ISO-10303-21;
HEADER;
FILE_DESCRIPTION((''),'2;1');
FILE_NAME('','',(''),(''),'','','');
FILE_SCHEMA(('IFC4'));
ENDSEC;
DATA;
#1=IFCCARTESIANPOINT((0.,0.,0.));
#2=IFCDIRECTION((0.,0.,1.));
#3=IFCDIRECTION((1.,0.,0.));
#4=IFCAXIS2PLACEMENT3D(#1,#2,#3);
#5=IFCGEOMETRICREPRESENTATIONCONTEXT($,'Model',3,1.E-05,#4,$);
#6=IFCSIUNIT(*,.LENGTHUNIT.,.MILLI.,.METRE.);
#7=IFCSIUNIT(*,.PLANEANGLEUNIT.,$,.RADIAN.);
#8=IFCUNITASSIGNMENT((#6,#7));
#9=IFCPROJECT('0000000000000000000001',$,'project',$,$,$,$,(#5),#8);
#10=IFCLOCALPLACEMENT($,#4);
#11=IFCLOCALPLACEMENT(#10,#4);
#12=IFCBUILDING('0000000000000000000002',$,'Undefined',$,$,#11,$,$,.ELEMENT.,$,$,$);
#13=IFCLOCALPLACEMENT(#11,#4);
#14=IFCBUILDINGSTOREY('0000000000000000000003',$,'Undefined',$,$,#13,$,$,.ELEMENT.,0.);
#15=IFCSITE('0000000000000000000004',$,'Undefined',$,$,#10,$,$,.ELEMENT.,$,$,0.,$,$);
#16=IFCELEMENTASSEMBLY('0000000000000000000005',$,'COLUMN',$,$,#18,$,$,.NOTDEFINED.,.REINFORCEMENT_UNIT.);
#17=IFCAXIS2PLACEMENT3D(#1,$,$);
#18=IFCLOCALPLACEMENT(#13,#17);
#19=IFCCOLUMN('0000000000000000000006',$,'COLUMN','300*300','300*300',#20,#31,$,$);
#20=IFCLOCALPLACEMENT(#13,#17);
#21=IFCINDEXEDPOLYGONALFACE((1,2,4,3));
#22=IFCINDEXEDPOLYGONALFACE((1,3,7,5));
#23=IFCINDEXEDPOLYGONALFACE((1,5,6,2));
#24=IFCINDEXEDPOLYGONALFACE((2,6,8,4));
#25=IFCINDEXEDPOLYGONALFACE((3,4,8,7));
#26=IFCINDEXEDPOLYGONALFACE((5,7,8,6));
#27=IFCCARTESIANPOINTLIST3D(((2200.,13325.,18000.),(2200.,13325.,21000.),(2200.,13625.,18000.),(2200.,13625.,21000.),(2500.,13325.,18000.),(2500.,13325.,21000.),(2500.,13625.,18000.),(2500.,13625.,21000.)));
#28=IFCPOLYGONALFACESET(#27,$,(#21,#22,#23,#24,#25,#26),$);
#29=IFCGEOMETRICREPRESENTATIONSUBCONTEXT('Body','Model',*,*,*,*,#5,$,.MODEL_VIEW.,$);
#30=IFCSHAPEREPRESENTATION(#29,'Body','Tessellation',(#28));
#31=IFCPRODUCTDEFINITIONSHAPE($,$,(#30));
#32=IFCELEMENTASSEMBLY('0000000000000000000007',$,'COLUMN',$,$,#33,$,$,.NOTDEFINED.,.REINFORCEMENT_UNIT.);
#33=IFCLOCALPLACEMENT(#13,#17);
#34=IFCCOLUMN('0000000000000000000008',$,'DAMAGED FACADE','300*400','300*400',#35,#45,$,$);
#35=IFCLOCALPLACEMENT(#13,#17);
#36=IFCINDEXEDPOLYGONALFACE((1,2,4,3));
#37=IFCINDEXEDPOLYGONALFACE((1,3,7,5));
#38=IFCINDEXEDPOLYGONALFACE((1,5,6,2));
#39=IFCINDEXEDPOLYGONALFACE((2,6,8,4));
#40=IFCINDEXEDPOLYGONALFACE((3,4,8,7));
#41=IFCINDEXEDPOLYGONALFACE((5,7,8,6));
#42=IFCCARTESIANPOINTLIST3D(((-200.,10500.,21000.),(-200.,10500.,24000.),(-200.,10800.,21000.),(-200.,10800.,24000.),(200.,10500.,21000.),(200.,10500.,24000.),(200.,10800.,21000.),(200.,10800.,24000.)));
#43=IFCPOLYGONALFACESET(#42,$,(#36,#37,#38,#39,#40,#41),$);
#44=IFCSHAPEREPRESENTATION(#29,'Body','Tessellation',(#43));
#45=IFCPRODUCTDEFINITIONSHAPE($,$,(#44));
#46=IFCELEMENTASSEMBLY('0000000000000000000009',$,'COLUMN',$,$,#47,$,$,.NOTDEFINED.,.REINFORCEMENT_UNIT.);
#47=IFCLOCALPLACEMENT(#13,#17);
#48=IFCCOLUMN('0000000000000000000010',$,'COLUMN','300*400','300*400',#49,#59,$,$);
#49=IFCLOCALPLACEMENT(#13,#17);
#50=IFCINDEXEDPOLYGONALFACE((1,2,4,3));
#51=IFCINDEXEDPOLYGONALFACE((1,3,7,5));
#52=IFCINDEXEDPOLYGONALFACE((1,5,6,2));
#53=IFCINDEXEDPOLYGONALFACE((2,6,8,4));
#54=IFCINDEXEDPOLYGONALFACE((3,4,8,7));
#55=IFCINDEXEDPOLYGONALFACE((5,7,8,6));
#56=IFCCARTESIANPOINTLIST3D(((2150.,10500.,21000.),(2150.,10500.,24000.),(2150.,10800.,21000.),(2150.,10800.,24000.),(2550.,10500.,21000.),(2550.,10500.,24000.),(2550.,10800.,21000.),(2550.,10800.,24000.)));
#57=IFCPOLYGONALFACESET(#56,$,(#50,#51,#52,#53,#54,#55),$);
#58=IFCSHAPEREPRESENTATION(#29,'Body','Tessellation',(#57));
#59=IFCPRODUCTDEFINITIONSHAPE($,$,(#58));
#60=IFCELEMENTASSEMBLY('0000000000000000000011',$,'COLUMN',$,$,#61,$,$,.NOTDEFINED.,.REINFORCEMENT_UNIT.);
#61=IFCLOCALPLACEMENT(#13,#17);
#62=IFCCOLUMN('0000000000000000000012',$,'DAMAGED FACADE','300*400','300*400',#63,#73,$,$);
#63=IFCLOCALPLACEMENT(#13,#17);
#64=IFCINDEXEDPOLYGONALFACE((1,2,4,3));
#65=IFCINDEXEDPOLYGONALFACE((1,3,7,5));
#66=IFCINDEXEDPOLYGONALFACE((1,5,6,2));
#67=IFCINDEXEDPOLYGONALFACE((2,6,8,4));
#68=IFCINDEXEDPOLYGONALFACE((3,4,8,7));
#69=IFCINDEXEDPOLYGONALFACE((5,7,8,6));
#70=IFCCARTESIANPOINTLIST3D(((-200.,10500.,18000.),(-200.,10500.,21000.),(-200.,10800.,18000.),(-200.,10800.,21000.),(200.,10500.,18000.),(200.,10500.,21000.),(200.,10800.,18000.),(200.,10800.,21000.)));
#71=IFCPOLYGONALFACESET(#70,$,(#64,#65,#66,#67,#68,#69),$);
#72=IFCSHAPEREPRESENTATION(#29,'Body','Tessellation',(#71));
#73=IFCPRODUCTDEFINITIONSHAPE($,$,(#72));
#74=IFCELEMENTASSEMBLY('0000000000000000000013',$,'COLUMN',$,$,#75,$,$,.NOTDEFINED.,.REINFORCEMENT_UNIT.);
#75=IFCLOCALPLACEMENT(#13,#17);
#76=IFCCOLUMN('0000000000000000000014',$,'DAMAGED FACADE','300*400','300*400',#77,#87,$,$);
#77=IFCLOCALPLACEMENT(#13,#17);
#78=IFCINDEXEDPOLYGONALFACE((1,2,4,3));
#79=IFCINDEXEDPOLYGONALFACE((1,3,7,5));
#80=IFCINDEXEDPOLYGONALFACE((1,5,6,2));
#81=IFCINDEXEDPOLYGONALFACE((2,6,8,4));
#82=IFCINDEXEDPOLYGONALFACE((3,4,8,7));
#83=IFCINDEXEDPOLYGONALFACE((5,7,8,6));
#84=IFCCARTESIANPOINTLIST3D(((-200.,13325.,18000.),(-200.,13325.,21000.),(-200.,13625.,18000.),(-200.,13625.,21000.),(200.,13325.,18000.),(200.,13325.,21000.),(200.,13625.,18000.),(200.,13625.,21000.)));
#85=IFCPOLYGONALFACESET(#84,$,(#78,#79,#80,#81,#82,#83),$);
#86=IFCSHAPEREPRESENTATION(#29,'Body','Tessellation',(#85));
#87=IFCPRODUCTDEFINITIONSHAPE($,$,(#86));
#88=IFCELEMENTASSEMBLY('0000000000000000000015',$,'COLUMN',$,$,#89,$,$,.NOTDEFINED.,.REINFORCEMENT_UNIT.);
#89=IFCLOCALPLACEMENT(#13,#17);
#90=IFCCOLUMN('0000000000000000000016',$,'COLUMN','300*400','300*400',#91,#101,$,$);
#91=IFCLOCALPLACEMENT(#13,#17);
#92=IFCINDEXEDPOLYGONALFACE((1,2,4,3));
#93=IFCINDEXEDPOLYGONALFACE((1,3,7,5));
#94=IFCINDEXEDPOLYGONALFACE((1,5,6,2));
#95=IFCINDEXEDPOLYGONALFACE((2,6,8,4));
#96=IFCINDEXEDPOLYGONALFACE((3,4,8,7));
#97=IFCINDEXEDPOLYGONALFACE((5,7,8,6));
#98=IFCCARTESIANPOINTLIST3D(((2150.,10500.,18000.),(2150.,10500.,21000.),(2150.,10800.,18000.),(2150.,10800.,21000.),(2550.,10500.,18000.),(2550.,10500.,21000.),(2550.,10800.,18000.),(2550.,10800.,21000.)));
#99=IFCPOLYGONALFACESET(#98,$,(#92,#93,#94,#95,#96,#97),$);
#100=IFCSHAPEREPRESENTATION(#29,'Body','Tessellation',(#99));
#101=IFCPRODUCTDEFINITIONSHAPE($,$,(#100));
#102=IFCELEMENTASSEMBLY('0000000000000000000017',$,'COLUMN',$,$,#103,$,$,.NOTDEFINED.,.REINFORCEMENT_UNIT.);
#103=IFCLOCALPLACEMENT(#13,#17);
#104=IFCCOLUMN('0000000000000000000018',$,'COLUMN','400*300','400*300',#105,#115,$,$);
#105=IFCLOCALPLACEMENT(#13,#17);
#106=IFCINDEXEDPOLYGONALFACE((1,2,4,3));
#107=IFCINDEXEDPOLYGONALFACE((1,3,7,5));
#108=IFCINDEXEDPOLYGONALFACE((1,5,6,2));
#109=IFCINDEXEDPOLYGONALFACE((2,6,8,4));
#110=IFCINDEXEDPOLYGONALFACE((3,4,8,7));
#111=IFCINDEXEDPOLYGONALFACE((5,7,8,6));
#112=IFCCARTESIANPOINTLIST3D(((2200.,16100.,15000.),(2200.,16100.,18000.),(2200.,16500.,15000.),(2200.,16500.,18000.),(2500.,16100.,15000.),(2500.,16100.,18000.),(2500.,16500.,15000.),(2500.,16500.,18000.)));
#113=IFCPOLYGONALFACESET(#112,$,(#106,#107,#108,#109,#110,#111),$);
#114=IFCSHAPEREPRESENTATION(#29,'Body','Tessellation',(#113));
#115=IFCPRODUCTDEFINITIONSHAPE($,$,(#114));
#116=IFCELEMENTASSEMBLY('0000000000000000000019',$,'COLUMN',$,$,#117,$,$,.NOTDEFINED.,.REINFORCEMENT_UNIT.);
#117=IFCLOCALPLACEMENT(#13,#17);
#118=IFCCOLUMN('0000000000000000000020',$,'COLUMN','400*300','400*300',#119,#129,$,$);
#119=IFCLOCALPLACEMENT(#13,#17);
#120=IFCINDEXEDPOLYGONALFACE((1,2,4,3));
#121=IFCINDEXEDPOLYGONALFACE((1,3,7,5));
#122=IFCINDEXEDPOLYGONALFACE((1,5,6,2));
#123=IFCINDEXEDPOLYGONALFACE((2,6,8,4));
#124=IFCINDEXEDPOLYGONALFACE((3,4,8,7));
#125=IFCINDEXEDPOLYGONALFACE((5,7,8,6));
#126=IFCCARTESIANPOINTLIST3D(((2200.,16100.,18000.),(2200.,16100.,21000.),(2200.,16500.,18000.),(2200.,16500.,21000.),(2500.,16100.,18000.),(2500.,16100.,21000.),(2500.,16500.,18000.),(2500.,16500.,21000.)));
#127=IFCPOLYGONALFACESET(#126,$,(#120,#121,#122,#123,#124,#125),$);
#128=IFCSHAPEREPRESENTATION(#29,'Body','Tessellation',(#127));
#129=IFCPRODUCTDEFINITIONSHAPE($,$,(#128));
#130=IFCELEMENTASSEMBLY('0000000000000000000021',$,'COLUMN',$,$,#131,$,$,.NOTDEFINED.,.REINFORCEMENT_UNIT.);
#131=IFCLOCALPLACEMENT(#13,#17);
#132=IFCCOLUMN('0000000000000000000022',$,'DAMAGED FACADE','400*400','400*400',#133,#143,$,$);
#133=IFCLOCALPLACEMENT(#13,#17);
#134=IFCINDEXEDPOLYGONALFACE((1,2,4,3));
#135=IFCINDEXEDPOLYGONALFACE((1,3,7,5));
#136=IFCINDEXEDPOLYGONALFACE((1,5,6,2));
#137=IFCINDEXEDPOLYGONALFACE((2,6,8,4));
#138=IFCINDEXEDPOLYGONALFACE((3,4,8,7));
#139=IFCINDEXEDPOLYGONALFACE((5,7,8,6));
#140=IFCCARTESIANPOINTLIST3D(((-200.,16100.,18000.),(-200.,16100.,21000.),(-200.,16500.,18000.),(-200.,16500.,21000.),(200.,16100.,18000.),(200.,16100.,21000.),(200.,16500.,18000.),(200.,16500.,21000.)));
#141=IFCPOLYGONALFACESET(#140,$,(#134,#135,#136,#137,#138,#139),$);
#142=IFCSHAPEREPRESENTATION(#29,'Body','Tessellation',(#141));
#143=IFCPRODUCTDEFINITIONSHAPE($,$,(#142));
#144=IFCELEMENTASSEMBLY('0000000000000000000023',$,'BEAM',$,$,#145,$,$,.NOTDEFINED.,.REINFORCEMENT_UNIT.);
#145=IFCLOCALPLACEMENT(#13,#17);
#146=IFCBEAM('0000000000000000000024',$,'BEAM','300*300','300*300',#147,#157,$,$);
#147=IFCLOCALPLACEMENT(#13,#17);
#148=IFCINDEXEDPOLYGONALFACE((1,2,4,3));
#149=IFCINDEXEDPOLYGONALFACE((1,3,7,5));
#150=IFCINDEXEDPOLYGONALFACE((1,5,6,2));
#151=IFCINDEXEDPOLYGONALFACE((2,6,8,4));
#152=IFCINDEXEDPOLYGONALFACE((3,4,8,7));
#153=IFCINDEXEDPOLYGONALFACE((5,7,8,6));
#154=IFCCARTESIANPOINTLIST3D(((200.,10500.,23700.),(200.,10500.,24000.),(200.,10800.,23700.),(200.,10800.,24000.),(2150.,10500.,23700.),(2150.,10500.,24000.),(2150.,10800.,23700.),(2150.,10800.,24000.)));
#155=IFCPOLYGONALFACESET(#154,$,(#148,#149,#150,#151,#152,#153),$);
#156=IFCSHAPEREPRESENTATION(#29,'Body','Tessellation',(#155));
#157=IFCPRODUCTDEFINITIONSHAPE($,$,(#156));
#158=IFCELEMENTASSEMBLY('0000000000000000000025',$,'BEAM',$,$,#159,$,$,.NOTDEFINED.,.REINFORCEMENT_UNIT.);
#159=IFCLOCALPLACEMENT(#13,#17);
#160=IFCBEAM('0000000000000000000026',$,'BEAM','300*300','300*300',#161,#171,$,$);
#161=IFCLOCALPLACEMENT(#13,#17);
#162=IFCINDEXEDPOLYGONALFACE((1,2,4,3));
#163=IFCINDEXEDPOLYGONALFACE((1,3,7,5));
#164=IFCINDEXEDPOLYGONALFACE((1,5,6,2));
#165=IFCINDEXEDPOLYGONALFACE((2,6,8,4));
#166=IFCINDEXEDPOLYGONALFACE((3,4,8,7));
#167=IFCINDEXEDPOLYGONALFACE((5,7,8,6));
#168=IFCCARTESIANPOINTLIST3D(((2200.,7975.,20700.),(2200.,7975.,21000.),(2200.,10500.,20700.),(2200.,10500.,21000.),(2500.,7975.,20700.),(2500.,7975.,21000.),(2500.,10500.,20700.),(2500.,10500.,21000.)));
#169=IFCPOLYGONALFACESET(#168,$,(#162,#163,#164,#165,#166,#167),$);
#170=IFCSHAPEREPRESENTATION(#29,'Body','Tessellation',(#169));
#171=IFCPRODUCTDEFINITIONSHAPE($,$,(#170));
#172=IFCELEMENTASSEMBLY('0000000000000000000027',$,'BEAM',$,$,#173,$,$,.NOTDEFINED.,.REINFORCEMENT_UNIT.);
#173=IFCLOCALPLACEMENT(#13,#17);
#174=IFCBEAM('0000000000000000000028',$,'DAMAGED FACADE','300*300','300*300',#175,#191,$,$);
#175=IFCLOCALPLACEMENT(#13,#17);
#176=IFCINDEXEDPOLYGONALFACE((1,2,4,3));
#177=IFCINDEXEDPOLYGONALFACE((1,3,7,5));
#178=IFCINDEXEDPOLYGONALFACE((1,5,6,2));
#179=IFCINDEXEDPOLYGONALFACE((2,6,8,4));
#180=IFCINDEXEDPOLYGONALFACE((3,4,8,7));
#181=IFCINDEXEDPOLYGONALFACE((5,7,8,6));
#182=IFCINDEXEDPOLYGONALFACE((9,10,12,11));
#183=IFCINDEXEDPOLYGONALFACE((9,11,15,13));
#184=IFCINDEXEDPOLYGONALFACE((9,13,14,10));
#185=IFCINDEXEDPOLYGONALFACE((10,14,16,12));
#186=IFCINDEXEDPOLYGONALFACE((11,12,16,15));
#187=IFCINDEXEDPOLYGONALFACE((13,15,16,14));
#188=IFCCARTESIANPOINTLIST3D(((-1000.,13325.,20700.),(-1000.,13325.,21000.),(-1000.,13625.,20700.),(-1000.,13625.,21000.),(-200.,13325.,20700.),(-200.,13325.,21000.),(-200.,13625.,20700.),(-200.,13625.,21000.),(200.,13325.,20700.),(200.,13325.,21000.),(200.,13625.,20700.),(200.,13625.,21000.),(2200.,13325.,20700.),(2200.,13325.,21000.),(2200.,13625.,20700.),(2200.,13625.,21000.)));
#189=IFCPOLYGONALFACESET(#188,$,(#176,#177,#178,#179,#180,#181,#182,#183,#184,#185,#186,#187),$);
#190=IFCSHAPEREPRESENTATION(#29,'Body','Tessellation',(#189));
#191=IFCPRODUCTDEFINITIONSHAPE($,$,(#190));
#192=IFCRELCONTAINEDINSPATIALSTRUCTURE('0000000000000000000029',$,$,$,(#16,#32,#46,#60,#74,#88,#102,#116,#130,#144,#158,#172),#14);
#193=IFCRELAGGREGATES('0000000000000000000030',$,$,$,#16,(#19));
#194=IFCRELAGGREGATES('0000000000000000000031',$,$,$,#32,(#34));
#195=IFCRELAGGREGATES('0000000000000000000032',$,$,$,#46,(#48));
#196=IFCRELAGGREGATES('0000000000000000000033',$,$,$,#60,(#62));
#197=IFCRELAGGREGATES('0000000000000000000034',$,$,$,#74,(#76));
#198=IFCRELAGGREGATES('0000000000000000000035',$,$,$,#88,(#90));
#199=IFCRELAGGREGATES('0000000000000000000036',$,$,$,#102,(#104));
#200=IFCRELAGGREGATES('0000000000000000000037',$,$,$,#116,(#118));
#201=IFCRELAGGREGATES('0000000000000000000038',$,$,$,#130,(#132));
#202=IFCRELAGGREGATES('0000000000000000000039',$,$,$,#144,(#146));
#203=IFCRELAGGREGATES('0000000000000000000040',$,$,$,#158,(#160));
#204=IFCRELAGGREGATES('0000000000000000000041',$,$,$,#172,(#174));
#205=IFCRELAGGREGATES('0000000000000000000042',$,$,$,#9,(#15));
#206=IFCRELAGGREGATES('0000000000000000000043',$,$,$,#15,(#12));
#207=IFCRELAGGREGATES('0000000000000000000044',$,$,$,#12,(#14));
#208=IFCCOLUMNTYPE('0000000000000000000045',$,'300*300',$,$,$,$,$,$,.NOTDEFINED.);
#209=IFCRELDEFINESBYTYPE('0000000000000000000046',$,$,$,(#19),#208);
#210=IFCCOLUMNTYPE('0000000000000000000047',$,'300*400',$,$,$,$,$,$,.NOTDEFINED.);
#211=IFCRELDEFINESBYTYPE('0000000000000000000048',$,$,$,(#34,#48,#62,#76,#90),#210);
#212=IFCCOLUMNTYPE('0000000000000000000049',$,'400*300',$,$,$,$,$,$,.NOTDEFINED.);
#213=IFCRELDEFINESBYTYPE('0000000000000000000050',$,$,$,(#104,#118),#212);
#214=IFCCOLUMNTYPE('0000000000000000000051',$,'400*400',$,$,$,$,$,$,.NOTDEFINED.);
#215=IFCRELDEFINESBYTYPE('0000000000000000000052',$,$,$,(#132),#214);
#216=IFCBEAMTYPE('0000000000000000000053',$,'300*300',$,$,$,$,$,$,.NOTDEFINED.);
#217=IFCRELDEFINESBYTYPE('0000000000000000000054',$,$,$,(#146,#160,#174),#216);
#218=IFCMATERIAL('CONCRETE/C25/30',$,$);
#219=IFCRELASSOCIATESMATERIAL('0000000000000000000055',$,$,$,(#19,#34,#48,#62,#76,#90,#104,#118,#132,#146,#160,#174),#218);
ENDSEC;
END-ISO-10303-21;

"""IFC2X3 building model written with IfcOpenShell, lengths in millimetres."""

from ifc_helpers import new_model, si_unit, frame, origin_with_axes, origin_2d_with_axis, place, context, subcontext, project, spatial, rectangle, extrude, boolean, material, type_object, element, aggregate, save


model = new_model("IFC2X3")

# Units and contexts
model_context = context("Model", 3, precision=1e-05, world=origin_with_axes())
body_context = subcontext(model_context, "Body", "Model", "MODEL_VIEW")
ifc_project = project(units=[si_unit("LENGTHUNIT", "METRE", prefix="MILLI"), si_unit("PLANEANGLEUNIT", "RADIAN")], contexts=[model_context])

# Site, building, storey
site_placement = place(None, origin_with_axes())
site = spatial("IfcSite", under=ifc_project, at=site_placement, Name="Undefined", CompositionType="ELEMENT", RefElevation=0.0)
building_placement = place(site_placement, origin_with_axes())
building = spatial("IfcBuilding", under=site, at=building_placement, Name="Undefined", CompositionType="ELEMENT")
storey_placement = place(building_placement, origin_with_axes())
storey = spatial("IfcBuildingStorey", under=building, at=storey_placement, Name="Undefined", CompositionType="ELEMENT", Elevation=0.0)

# Element assemblies, columns
assembly_1_placement = place(storey_placement, origin_with_axes())
assembly_1 = element("IfcElementAssembly", 1, at=assembly_1_placement, inside=storey, Name="COLUMN", AssemblyPlace="NOTDEFINED", PredefinedType="REINFORCEMENT_UNIT")
ifc_material = material(Name="CONCRETE/C25/30")
column_type_1 = type_object("IfcColumnType", Name="300*300", PredefinedType="NOTDEFINED")
column_1_placement = place(assembly_1_placement, frame((2350.0, 13475.0, 18000.0), z_axis=(0.0, 0.0, 1.0), x_axis=(1.0, 0.0, 0.0)))
column_1 = element("IfcColumn", 2, at=column_1_placement, type_object=column_type_1, material=ifc_material, Name="COLUMN", Description="300*300", ObjectType="300*300", context=body_context, shape_type="SweptSolid", body=[
    extrude(rectangle(XDim=300.0, YDim=300.0, at=origin_2d_with_axis()), frame((0.0, 0.0, 3000.0), z_axis=(0.0, 0.0, -1.0), x_axis=(-1.0, 0.0, 0.0)), (0.0, 0.0, 1.0), 3000.0),
])
aggregate(assembly_1, [column_1])
assembly_2_placement = place(storey_placement, origin_with_axes())
assembly_2 = element("IfcElementAssembly", 3, at=assembly_2_placement, inside=storey, Name="COLUMN", AssemblyPlace="NOTDEFINED", PredefinedType="REINFORCEMENT_UNIT")
column_type_2 = type_object("IfcColumnType", Name="300*400", PredefinedType="NOTDEFINED")
column_2_placement = place(assembly_2_placement, frame((0.0, 10650.0, 21000.0), z_axis=(0.0, 0.0, 1.0), x_axis=(1.0, 0.0, 0.0)))
column_2 = element("IfcColumn", 4, at=column_2_placement, type_object=column_type_2, material=ifc_material, Name="DAMAGED FACADE", Description="300*400", ObjectType="300*400", context=body_context, shape_type="SweptSolid", body=[
    extrude(rectangle(XDim=400.0, YDim=300.0, at=origin_2d_with_axis()), frame((0.0, 0.0, 3000.0), z_axis=(0.0, 0.0, -1.0), x_axis=(-1.0, 0.0, 0.0)), (0.0, 0.0, 1.0), 3000.0),
])
aggregate(assembly_2, [column_2])
assembly_3_placement = place(storey_placement, origin_with_axes())
assembly_3 = element("IfcElementAssembly", 5, at=assembly_3_placement, inside=storey, Name="COLUMN", AssemblyPlace="NOTDEFINED", PredefinedType="REINFORCEMENT_UNIT")
column_3_placement = place(assembly_3_placement, frame((2350.0, 10650.0, 21000.0), z_axis=(0.0, 0.0, 1.0), x_axis=(1.0, 0.0, 0.0)))
column_3 = element("IfcColumn", 6, at=column_3_placement, type_object=column_type_2, material=ifc_material, Name="COLUMN", Description="300*400", ObjectType="300*400", context=body_context, shape_type="SweptSolid", body=[
    extrude(rectangle(XDim=400.0, YDim=300.0, at=origin_2d_with_axis()), frame((0.0, 0.0, 3000.0), z_axis=(0.0, 0.0, -1.0), x_axis=(-1.0, 0.0, 0.0)), (0.0, 0.0, 1.0), 3000.0),
])
aggregate(assembly_3, [column_3])
assembly_4_placement = place(storey_placement, origin_with_axes())
assembly_4 = element("IfcElementAssembly", 7, at=assembly_4_placement, inside=storey, Name="COLUMN", AssemblyPlace="NOTDEFINED", PredefinedType="REINFORCEMENT_UNIT")
column_4_placement = place(assembly_4_placement, frame((0.0, 10650.0, 18000.0), z_axis=(0.0, 0.0, 1.0), x_axis=(1.0, 0.0, 0.0)))
column_4 = element("IfcColumn", 8, at=column_4_placement, type_object=column_type_2, material=ifc_material, Name="DAMAGED FACADE", Description="300*400", ObjectType="300*400", context=body_context, shape_type="SweptSolid", body=[
    extrude(rectangle(XDim=400.0, YDim=300.0, at=origin_2d_with_axis()), frame((0.0, 0.0, 3000.0), z_axis=(0.0, 0.0, -1.0), x_axis=(-1.0, 0.0, 0.0)), (0.0, 0.0, 1.0), 3000.0),
])
aggregate(assembly_4, [column_4])
assembly_5_placement = place(storey_placement, origin_with_axes())
assembly_5 = element("IfcElementAssembly", 9, at=assembly_5_placement, inside=storey, Name="COLUMN", AssemblyPlace="NOTDEFINED", PredefinedType="REINFORCEMENT_UNIT")
column_5_placement = place(assembly_5_placement, frame((0.0, 13475.0, 18000.0), z_axis=(0.0, 0.0, 1.0), x_axis=(1.0, 0.0, 0.0)))
column_5 = element("IfcColumn", 10, at=column_5_placement, type_object=column_type_2, material=ifc_material, Name="DAMAGED FACADE", Description="300*400", ObjectType="300*400", context=body_context, shape_type="SweptSolid", body=[
    extrude(rectangle(XDim=400.0, YDim=300.0, at=origin_2d_with_axis()), frame((0.0, 0.0, 3000.0), z_axis=(0.0, 0.0, -1.0), x_axis=(-1.0, 0.0, 0.0)), (0.0, 0.0, 1.0), 3000.0),
])
aggregate(assembly_5, [column_5])
assembly_6_placement = place(storey_placement, origin_with_axes())
assembly_6 = element("IfcElementAssembly", 11, at=assembly_6_placement, inside=storey, Name="COLUMN", AssemblyPlace="NOTDEFINED", PredefinedType="REINFORCEMENT_UNIT")
column_6_placement = place(assembly_6_placement, frame((2350.0, 10650.0, 18000.0), z_axis=(0.0, 0.0, 1.0), x_axis=(1.0, 0.0, 0.0)))
column_6 = element("IfcColumn", 12, at=column_6_placement, type_object=column_type_2, material=ifc_material, Name="COLUMN", Description="300*400", ObjectType="300*400", context=body_context, shape_type="SweptSolid", body=[
    extrude(rectangle(XDim=400.0, YDim=300.0, at=origin_2d_with_axis()), frame((0.0, 0.0, 3000.0), z_axis=(0.0, 0.0, -1.0), x_axis=(-1.0, 0.0, 0.0)), (0.0, 0.0, 1.0), 3000.0),
])
aggregate(assembly_6, [column_6])
assembly_7_placement = place(storey_placement, origin_with_axes())
assembly_7 = element("IfcElementAssembly", 13, at=assembly_7_placement, inside=storey, Name="COLUMN", AssemblyPlace="NOTDEFINED", PredefinedType="REINFORCEMENT_UNIT")
column_type_3 = type_object("IfcColumnType", Name="400*300", PredefinedType="NOTDEFINED")
column_7_placement = place(assembly_7_placement, frame((2350.0, 16300.0, 15000.0), z_axis=(0.0, 0.0, 1.0), x_axis=(1.0, 0.0, 0.0)))
column_7 = element("IfcColumn", 14, at=column_7_placement, type_object=column_type_3, material=ifc_material, Name="COLUMN", Description="400*300", ObjectType="400*300", context=body_context, shape_type="SweptSolid", body=[
    extrude(rectangle(XDim=300.0, YDim=400.0, at=origin_2d_with_axis()), frame((0.0, 0.0, 3000.0), z_axis=(0.0, 0.0, -1.0), x_axis=(-1.0, 0.0, 0.0)), (0.0, 0.0, 1.0), 3000.0),
])
aggregate(assembly_7, [column_7])
assembly_8_placement = place(storey_placement, origin_with_axes())
assembly_8 = element("IfcElementAssembly", 15, at=assembly_8_placement, inside=storey, Name="COLUMN", AssemblyPlace="NOTDEFINED", PredefinedType="REINFORCEMENT_UNIT")
column_8_placement = place(assembly_8_placement, frame((2350.0, 16300.0, 18000.0), z_axis=(0.0, 0.0, 1.0), x_axis=(1.0, 0.0, 0.0)))
column_8 = element("IfcColumn", 16, at=column_8_placement, type_object=column_type_3, material=ifc_material, Name="COLUMN", Description="400*300", ObjectType="400*300", context=body_context, shape_type="SweptSolid", body=[
    extrude(rectangle(XDim=300.0, YDim=400.0, at=origin_2d_with_axis()), frame((0.0, 0.0, 3000.0), z_axis=(0.0, 0.0, -1.0), x_axis=(-1.0, 0.0, 0.0)), (0.0, 0.0, 1.0), 3000.0),
])
aggregate(assembly_8, [column_8])
assembly_9_placement = place(storey_placement, origin_with_axes())
assembly_9 = element("IfcElementAssembly", 17, at=assembly_9_placement, inside=storey, Name="COLUMN", AssemblyPlace="NOTDEFINED", PredefinedType="REINFORCEMENT_UNIT")
column_type_4 = type_object("IfcColumnType", Name="400*400", PredefinedType="NOTDEFINED")
column_9_placement = place(assembly_9_placement, frame((0.0, 16300.0, 18000.0), z_axis=(0.0, 0.0, 1.0), x_axis=(1.0, 0.0, 0.0)))
column_9 = element("IfcColumn", 18, at=column_9_placement, type_object=column_type_4, material=ifc_material, Name="DAMAGED FACADE", Description="400*400", ObjectType="400*400", context=body_context, shape_type="SweptSolid", body=[
    extrude(rectangle(XDim=400.0, YDim=400.0, at=origin_2d_with_axis()), frame((0.0, 0.0, 3000.0), z_axis=(0.0, 0.0, -1.0), x_axis=(-1.0, 0.0, 0.0)), (0.0, 0.0, 1.0), 3000.0),
])
aggregate(assembly_9, [column_9])

# Element assemblies, beams
beam_type_1 = type_object("IfcBeamType", Name="300*300", PredefinedType="NOTDEFINED")
assembly_10_placement = place(storey_placement, origin_with_axes())
assembly_10 = element("IfcElementAssembly", 19, at=assembly_10_placement, inside=storey, Name="BEAM", AssemblyPlace="NOTDEFINED", PredefinedType="REINFORCEMENT_UNIT")
beam_1_placement = place(assembly_10_placement, frame((2350.0, 10650.0, 23850.0), z_axis=(0.0, 0.0, 1.0), x_axis=(-1.0, 0.0, 0.0)))
beam_1 = element("IfcBeam", 20, at=beam_1_placement, type_object=beam_type_1, material=ifc_material, Name="BEAM", Description="300*300", ObjectType="300*300", context=body_context, shape_type="SweptSolid", body=[
    extrude(rectangle(XDim=300.0, YDim=300.0, at=origin_2d_with_axis()), frame((2150.0, 0.0, 0.0), z_axis=(-1.0, 0.0, 0.0), x_axis=(0.0, -1.0, 0.0)), (0.0, 0.0, 1.0), 1950.0),
])
aggregate(assembly_10, [beam_1])
assembly_11_placement = place(storey_placement, origin_with_axes())
assembly_11 = element("IfcElementAssembly", 21, at=assembly_11_placement, inside=storey, Name="BEAM", AssemblyPlace="NOTDEFINED", PredefinedType="REINFORCEMENT_UNIT")
beam_2_placement = place(assembly_11_placement, frame((2350.0, 10500.0, 20850.0), z_axis=(0.0, 0.0, 1.0), x_axis=(0.0, -1.0, 0.0)))
beam_2 = element("IfcBeam", 22, at=beam_2_placement, type_object=beam_type_1, material=ifc_material, Name="BEAM", Description="300*300", ObjectType="300*300", context=body_context, shape_type="SweptSolid", body=[
    extrude(rectangle(XDim=300.0, YDim=300.0, at=origin_2d_with_axis()), frame((2525.0, 0.0, 0.0), z_axis=(-1.0, 0.0, 0.0), x_axis=(0.0, -1.0, 0.0)), (0.0, 0.0, 1.0), 2525.0),
])
aggregate(assembly_11, [beam_2])
assembly_12_placement = place(storey_placement, origin_with_axes())
assembly_12 = element("IfcElementAssembly", 23, at=assembly_12_placement, inside=storey, Name="BEAM", AssemblyPlace="NOTDEFINED", PredefinedType="REINFORCEMENT_UNIT")
beam_3_placement = place(assembly_12_placement, frame((2200.0, 13475.0, 20850.0), z_axis=(0.0, 0.0, 1.0), x_axis=(-1.0, 0.0, 0.0)))
beam_3 = element("IfcBeam", 24, at=beam_3_placement, type_object=beam_type_1, material=ifc_material, Name="DAMAGED FACADE", Description="300*300", ObjectType="300*300", context=body_context, shape_type="CSG", body=[
    boolean("DIFFERENCE", extrude(rectangle(XDim=300.0, YDim=300.0, at=origin_2d_with_axis()), frame((3200.0, 0.0, 0.0), z_axis=(-1.0, 0.0, 0.0), x_axis=(0.0, -1.0, 0.0)), (0.0, 0.0, 1.0), 3200.0), extrude(rectangle(XDim=400.0, YDim=300.0, at=origin_2d_with_axis()), frame((2200.0, 0.0, 150.0), z_axis=(0.0, 0.0, -1.0), x_axis=(1.0, 0.0, 0.0)), (0.0, 0.0, 1.0), 3000.0)),
])
aggregate(assembly_12, [beam_3])

save(model, "model.ifc")
